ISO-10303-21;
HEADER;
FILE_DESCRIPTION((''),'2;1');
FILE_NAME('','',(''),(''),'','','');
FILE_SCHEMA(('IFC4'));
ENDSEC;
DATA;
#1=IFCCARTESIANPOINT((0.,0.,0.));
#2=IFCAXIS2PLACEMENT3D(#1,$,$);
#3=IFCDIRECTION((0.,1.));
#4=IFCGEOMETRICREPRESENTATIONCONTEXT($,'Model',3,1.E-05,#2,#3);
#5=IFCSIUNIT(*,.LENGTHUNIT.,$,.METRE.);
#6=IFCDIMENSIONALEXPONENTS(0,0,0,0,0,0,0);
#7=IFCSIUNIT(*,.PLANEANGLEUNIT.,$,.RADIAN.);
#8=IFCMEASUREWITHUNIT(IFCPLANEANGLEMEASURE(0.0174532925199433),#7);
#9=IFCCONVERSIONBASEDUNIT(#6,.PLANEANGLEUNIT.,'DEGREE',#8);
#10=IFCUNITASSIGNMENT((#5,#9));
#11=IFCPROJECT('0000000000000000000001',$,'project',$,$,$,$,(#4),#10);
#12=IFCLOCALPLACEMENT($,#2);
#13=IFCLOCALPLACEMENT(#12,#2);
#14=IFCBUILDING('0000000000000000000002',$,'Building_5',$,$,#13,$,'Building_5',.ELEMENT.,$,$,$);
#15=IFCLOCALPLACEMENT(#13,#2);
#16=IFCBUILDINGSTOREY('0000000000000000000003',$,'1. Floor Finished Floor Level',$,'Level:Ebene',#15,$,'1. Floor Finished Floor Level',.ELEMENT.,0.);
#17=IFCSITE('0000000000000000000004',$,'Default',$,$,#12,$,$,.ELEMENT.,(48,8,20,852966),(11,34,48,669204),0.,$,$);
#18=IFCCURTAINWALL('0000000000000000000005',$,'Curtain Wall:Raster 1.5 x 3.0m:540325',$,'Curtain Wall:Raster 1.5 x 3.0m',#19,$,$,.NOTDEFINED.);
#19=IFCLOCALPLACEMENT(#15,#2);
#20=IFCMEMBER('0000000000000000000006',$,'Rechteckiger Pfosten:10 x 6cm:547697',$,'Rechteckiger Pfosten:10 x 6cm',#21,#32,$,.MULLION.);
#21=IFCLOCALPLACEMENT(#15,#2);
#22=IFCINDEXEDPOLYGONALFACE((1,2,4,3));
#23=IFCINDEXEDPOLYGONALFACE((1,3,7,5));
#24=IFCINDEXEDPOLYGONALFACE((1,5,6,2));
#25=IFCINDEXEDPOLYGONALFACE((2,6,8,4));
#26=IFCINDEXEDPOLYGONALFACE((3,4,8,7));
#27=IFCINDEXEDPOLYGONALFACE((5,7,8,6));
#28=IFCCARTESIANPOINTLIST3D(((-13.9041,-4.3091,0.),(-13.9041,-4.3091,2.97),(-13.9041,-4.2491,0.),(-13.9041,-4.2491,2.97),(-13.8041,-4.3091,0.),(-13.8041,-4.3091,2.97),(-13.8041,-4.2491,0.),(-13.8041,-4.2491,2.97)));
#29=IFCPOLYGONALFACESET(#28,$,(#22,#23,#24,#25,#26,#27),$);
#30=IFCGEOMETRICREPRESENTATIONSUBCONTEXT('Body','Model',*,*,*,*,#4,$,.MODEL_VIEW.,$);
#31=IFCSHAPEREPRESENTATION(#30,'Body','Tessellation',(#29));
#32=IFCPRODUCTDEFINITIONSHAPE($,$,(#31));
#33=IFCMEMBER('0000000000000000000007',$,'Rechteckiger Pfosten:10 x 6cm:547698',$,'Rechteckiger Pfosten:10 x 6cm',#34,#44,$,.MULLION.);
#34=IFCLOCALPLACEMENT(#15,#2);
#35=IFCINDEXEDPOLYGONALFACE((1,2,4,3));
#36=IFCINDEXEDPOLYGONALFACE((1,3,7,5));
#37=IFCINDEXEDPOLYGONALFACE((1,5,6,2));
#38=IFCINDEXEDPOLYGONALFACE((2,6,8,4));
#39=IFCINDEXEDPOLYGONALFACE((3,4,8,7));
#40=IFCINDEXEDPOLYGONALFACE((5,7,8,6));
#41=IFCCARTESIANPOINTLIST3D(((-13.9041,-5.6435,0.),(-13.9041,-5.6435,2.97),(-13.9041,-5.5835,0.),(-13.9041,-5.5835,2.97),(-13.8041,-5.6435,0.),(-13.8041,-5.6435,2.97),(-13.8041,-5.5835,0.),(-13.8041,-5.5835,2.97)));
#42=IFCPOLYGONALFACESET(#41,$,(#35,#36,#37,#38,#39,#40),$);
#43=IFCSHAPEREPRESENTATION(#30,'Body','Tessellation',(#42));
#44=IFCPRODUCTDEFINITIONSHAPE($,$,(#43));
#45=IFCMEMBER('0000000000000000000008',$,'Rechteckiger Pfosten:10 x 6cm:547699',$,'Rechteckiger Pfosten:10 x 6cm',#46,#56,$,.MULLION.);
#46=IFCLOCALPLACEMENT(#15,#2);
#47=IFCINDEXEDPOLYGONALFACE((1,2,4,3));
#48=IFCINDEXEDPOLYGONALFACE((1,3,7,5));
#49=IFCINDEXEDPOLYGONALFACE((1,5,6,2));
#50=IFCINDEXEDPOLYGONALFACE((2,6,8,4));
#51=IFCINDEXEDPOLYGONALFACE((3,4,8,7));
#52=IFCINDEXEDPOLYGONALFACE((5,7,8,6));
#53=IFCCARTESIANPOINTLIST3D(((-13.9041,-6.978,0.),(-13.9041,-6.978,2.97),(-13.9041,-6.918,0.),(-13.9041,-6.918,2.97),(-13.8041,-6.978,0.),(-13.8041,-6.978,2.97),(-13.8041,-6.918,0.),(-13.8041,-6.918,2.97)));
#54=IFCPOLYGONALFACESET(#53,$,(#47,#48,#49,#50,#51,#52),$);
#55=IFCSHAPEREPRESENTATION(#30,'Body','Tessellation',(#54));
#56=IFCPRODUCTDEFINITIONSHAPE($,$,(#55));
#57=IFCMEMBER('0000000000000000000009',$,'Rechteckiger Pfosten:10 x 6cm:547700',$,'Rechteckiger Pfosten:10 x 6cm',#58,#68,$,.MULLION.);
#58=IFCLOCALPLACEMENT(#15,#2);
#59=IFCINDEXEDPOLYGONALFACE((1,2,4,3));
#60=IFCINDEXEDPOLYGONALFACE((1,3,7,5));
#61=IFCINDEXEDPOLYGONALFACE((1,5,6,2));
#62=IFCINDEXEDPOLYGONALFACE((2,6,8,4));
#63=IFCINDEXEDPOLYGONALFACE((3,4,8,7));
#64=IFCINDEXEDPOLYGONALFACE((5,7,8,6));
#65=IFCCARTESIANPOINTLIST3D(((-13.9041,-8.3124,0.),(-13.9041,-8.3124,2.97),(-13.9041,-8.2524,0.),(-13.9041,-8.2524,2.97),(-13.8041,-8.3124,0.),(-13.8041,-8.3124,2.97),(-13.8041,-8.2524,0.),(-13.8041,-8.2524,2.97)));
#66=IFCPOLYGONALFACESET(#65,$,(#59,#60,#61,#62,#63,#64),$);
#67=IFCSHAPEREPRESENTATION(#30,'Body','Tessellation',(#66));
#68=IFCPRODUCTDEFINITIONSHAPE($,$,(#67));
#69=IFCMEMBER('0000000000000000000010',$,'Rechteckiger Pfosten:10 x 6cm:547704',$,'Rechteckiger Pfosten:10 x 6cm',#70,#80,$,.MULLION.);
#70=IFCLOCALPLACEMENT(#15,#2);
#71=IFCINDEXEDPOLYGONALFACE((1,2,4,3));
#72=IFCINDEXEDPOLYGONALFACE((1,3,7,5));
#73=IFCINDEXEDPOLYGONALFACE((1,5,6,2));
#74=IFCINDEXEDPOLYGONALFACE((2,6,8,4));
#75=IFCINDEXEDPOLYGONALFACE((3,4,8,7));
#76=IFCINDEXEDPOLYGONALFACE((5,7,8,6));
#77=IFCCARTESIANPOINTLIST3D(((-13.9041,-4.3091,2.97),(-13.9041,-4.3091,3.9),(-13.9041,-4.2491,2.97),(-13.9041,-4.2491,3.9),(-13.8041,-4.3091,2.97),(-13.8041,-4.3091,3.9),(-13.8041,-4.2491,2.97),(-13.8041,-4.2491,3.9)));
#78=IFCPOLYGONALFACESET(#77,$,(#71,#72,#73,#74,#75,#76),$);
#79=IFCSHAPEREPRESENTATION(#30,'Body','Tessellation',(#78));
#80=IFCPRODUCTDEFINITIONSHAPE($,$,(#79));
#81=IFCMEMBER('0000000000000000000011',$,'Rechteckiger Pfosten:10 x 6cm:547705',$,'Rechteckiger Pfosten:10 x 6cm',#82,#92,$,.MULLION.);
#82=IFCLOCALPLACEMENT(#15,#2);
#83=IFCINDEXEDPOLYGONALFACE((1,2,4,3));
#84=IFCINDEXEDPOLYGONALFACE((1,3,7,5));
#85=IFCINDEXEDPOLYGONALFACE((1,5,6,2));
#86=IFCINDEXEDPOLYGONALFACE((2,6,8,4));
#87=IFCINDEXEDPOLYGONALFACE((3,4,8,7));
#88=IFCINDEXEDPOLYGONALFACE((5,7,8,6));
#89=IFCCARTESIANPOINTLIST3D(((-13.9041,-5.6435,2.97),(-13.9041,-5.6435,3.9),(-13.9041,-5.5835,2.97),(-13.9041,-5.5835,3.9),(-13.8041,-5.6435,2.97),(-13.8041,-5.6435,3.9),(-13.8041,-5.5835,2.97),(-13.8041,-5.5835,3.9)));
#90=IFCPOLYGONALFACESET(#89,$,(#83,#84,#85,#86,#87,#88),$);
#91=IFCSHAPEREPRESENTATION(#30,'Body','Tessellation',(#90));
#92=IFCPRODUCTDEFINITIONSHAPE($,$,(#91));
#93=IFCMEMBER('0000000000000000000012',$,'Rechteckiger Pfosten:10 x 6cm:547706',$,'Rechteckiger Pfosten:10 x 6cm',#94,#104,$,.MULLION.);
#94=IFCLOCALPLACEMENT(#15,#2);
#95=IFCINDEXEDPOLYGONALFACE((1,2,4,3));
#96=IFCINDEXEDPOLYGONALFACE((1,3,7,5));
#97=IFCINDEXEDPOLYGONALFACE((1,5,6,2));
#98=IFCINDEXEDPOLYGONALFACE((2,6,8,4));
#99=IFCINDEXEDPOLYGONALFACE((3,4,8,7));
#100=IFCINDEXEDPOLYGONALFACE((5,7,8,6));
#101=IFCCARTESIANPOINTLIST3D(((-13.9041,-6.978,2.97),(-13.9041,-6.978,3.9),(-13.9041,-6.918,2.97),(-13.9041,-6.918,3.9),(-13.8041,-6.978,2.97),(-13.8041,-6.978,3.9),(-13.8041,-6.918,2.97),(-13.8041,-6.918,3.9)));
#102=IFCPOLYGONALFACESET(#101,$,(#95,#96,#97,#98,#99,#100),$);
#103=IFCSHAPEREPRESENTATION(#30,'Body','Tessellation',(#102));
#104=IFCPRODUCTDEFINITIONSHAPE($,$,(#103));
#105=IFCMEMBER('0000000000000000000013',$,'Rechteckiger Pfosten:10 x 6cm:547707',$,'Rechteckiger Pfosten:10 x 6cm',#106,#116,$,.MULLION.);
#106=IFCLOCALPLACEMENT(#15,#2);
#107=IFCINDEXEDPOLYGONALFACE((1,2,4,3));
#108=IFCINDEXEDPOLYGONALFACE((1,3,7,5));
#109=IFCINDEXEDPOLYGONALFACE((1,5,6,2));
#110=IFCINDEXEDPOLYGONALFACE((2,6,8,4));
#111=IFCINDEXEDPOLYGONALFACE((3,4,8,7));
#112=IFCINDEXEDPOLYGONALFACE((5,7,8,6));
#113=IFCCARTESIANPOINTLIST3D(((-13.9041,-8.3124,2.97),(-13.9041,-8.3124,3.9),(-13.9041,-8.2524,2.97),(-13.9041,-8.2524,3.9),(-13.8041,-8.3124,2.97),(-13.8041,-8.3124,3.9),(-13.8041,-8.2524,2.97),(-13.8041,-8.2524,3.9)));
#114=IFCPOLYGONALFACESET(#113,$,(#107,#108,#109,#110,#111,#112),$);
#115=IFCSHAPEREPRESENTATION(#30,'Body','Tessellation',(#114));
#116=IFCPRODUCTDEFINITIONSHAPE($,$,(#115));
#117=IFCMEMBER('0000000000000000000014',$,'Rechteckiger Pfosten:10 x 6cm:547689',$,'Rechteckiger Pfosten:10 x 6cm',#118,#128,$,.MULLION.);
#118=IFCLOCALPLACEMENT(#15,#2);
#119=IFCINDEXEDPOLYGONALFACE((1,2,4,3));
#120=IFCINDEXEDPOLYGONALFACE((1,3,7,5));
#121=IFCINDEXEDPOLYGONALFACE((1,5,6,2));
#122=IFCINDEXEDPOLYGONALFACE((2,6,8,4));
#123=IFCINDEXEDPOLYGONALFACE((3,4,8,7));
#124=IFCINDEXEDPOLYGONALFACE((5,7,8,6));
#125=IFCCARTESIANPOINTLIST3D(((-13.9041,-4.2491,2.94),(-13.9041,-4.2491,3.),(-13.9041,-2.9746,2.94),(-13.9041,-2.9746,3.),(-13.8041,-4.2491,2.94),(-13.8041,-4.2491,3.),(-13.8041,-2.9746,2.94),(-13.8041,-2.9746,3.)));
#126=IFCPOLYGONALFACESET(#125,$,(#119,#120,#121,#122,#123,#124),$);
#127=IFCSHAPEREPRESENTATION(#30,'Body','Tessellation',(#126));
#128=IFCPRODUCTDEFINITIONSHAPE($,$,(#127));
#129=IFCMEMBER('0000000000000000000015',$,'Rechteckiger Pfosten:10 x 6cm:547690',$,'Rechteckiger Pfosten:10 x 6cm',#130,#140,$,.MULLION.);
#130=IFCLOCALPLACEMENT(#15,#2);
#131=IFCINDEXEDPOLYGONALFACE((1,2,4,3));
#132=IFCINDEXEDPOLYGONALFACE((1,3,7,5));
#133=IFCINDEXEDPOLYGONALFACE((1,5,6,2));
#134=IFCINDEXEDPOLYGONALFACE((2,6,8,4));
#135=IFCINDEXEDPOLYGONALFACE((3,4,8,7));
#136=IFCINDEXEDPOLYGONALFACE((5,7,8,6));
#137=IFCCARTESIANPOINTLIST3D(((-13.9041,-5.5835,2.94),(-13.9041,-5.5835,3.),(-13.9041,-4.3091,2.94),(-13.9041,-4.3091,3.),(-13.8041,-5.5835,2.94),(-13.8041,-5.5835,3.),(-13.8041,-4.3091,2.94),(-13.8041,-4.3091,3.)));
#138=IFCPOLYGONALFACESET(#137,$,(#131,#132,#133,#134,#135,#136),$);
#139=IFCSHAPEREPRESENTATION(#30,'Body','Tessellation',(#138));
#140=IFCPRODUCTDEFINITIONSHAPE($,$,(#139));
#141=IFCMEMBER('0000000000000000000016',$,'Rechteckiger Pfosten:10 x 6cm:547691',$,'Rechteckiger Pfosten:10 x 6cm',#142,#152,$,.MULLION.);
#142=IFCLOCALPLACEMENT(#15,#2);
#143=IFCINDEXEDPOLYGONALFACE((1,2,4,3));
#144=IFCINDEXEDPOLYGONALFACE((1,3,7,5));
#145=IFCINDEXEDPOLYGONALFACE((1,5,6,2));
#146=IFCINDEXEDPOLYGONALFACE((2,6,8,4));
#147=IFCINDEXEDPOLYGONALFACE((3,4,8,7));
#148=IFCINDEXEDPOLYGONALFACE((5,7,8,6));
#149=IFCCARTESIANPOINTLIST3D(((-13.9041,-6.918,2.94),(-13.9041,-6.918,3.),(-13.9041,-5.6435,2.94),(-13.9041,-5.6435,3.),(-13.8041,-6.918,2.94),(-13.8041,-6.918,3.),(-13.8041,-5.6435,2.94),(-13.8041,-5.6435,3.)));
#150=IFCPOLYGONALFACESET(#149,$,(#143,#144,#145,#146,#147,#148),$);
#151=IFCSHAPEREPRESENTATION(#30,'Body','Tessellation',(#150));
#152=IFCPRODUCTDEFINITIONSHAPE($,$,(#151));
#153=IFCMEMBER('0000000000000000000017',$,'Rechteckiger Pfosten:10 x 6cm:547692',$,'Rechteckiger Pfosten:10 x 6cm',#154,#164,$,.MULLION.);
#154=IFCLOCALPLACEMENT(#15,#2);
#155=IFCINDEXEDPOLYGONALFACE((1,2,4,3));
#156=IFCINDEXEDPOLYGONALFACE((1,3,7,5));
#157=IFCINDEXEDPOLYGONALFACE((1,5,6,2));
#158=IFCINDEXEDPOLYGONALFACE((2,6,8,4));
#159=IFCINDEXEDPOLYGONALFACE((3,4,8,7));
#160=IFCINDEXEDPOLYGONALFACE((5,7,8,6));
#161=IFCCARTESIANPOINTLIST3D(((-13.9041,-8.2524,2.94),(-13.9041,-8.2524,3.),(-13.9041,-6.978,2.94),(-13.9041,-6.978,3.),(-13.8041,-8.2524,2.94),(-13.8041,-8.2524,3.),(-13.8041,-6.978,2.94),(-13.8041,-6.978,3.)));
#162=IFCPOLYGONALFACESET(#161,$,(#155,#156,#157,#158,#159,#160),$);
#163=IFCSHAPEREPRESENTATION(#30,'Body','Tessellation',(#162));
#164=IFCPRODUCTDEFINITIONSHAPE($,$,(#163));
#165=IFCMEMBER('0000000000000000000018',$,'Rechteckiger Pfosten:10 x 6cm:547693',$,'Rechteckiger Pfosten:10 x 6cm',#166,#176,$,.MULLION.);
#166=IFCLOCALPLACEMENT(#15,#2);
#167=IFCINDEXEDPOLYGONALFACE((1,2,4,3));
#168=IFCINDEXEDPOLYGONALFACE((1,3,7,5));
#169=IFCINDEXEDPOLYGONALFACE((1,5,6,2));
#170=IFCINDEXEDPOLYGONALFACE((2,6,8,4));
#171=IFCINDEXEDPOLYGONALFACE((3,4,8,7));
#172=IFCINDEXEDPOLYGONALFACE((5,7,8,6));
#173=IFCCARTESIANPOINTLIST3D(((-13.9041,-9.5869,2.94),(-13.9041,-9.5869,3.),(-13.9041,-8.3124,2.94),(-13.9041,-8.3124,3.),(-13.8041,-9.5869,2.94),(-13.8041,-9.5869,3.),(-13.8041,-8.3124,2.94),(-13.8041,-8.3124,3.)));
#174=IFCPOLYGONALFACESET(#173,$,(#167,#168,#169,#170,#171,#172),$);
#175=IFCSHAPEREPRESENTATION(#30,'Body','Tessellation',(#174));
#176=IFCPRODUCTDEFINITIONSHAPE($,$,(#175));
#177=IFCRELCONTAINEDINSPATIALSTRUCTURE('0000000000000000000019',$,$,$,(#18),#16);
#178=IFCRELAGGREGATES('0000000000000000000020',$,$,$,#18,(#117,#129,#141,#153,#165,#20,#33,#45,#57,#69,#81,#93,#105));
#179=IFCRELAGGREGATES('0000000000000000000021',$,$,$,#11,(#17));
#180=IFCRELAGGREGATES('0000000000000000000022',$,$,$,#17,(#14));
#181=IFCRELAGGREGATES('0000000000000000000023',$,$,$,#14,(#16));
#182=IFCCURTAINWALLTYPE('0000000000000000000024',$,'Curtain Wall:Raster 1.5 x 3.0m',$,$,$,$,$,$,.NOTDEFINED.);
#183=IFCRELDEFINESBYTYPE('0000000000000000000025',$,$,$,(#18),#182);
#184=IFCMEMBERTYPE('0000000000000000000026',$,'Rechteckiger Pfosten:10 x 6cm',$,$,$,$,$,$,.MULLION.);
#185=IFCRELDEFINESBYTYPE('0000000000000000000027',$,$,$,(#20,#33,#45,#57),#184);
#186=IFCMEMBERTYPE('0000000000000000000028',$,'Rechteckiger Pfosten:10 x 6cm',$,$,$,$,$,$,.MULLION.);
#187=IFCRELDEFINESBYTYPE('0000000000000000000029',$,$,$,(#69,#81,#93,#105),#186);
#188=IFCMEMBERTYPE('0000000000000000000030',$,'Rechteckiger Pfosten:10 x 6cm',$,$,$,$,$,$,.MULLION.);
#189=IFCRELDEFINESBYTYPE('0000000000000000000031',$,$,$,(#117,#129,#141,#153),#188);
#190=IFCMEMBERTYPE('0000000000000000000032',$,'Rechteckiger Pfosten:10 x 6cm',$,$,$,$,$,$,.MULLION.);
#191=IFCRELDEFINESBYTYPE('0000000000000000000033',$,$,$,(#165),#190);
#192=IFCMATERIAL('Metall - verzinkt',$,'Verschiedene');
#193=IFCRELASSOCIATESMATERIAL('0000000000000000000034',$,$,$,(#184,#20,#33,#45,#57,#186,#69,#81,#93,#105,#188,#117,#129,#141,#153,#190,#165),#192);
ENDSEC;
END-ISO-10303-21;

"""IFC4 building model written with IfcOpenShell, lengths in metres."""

from ifc_helpers import new_model, entity, si_unit, converted_unit, direction, frame, origin, place, context, subcontext, project, spatial, indexed_curve, outline, extrude, source, transform, mapped, material, type_object, type_shapes, element, aggregate, save


model = new_model("IFC4")

# Units and contexts
model_context = context("Model", 3, precision=1e-05, world=origin(), true_north=direction((0.0, 1.0)))
body_context = subcontext(model_context, "Body", "Model", "MODEL_VIEW")
ifc_project = project(units=[si_unit("LENGTHUNIT", "METRE"), converted_unit("PLANEANGLEUNIT", "DEGREE", entity("IfcPlaneAngleMeasure", 0.0174532925199433), si_unit("PLANEANGLEUNIT", "RADIAN"), dimensions=[0, 0, 0, 0, 0, 0, 0])], contexts=[model_context])

# Site, building, storey
site_placement = place(None, origin())
site = spatial("IfcSite", under=ifc_project, at=site_placement, Name="Default", CompositionType="ELEMENT", RefLatitude=(48, 8, 20, 852966), RefLongitude=(11, 34, 48, 669204), RefElevation=0.0)
building_placement = place(site_placement, origin())
building = spatial("IfcBuilding", under=site, at=building_placement, Name="Building_5", LongName="Building_5", CompositionType="ELEMENT")
storey_placement = place(building_placement, origin())
storey = spatial("IfcBuildingStorey", under=building, at=storey_placement, Name="1. Floor Finished Floor Level", ObjectType="Level:Ebene", LongName="1. Floor Finished Floor Level", CompositionType="ELEMENT", Elevation=0.0)

# Curtain wall, members
curtain_wall_type = type_object("IfcCurtainWallType", Name="Curtain Wall:Raster 1.5 x 3.0m", PredefinedType="NOTDEFINED")
curtain_wall_placement = place(storey_placement, origin())
curtain_wall = element("IfcCurtainWall", 1, at=curtain_wall_placement, inside=storey, type_object=curtain_wall_type, Name="Curtain Wall:Raster 1.5 x 3.0m:540325", ObjectType="Curtain Wall:Raster 1.5 x 3.0m", PredefinedType="NOTDEFINED")
ifc_material_1 = material(Name="Metall - verzinkt", Category="Verschiedene")
member_type_1 = type_object("IfcMemberType", Name="Rechteckiger Pfosten:10 x 6cm", PredefinedType="MULLION", material=ifc_material_1)
shared_shape_1 = source(origin(), body_context, "Body", "SweptSolid", [
    extrude(outline(indexed_curve([(-0.03, -0.05), (0.03, -0.05), (0.03, 0.05), (-0.03, 0.05), (-0.03, -0.05)], self_intersect=False)), frame((0.0, 0.0, -2.97), z_axis=(0.0, 0.0, 1.0), x_axis=(-1.0, 0.0, 0.0)), (0.0, 0.0, 1.0), 2.97),
])
type_shapes(member_type_1, [shared_shape_1])
member_1_placement = place(curtain_wall_placement, frame((-13.8541, -4.2791, 0.0), z_axis=(0.0, 0.0, -1.0), x_axis=(0.0, -1.0, 0.0)))
member_1 = element("IfcMember", 2, at=member_1_placement, type_object=member_type_1, material=ifc_material_1, Name="Rechteckiger Pfosten:10 x 6cm:547697", ObjectType="Rechteckiger Pfosten:10 x 6cm", PredefinedType="MULLION", context=body_context, shape_type="MappedRepresentation", body=[
    mapped(shared_shape_1, transform((0.0, 0.0, 0.0), scale=1.0)),
])
member_2_placement = place(curtain_wall_placement, frame((-13.8541, -5.6135, 0.0), z_axis=(0.0, 0.0, -1.0), x_axis=(0.0, -1.0, 0.0)))
member_2 = element("IfcMember", 3, at=member_2_placement, type_object=member_type_1, material=ifc_material_1, Name="Rechteckiger Pfosten:10 x 6cm:547698", ObjectType="Rechteckiger Pfosten:10 x 6cm", PredefinedType="MULLION", context=body_context, shape_type="MappedRepresentation", body=[
    mapped(shared_shape_1, transform((0.0, 0.0, 0.0), scale=1.0)),
])
member_3_placement = place(curtain_wall_placement, frame((-13.8541, -6.948, 0.0), z_axis=(0.0, 0.0, -1.0), x_axis=(0.0, -1.0, 0.0)))
member_3 = element("IfcMember", 4, at=member_3_placement, type_object=member_type_1, material=ifc_material_1, Name="Rechteckiger Pfosten:10 x 6cm:547699", ObjectType="Rechteckiger Pfosten:10 x 6cm", PredefinedType="MULLION", context=body_context, shape_type="MappedRepresentation", body=[
    mapped(shared_shape_1, transform((0.0, 0.0, 0.0), scale=1.0)),
])
member_4_placement = place(curtain_wall_placement, frame((-13.8541, -8.2824, 0.0), z_axis=(0.0, 0.0, -1.0), x_axis=(0.0, -1.0, 0.0)))
member_4 = element("IfcMember", 5, at=member_4_placement, type_object=member_type_1, material=ifc_material_1, Name="Rechteckiger Pfosten:10 x 6cm:547700", ObjectType="Rechteckiger Pfosten:10 x 6cm", PredefinedType="MULLION", context=body_context, shape_type="MappedRepresentation", body=[
    mapped(shared_shape_1, transform((0.0, 0.0, 0.0), scale=1.0)),
])
member_type_2 = type_object("IfcMemberType", Name="Rechteckiger Pfosten:10 x 6cm", PredefinedType="MULLION", material=ifc_material_1)
shared_shape_2 = source(origin(), body_context, "Body", "SweptSolid", [
    extrude(outline(indexed_curve([(-0.03, -0.05), (0.03, -0.05), (0.03, 0.05), (-0.03, 0.05), (-0.03, -0.05)], self_intersect=False)), frame((0.0, 0.0, -0.93), z_axis=(0.0, 0.0, 1.0), x_axis=(-1.0, 0.0, 0.0)), (0.0, 0.0, 1.0), 0.93),
])
type_shapes(member_type_2, [shared_shape_2])
member_5_placement = place(curtain_wall_placement, frame((-13.8541, -4.2791, 2.97), z_axis=(0.0, 0.0, -1.0), x_axis=(0.0, -1.0, 0.0)))
member_5 = element("IfcMember", 6, at=member_5_placement, type_object=member_type_2, material=ifc_material_1, Name="Rechteckiger Pfosten:10 x 6cm:547704", ObjectType="Rechteckiger Pfosten:10 x 6cm", PredefinedType="MULLION", context=body_context, shape_type="MappedRepresentation", body=[
    mapped(shared_shape_2, transform((0.0, 0.0, 0.0), scale=1.0)),
])
member_6_placement = place(curtain_wall_placement, frame((-13.8541, -5.6135, 2.97), z_axis=(0.0, 0.0, -1.0), x_axis=(0.0, -1.0, 0.0)))
member_6 = element("IfcMember", 7, at=member_6_placement, type_object=member_type_2, material=ifc_material_1, Name="Rechteckiger Pfosten:10 x 6cm:547705", ObjectType="Rechteckiger Pfosten:10 x 6cm", PredefinedType="MULLION", context=body_context, shape_type="MappedRepresentation", body=[
    mapped(shared_shape_2, transform((0.0, 0.0, 0.0), scale=1.0)),
])
member_7_placement = place(curtain_wall_placement, frame((-13.8541, -6.948, 2.97), z_axis=(0.0, 0.0, -1.0), x_axis=(0.0, -1.0, 0.0)))
member_7 = element("IfcMember", 8, at=member_7_placement, type_object=member_type_2, material=ifc_material_1, Name="Rechteckiger Pfosten:10 x 6cm:547706", ObjectType="Rechteckiger Pfosten:10 x 6cm", PredefinedType="MULLION", context=body_context, shape_type="MappedRepresentation", body=[
    mapped(shared_shape_2, transform((0.0, 0.0, 0.0), scale=1.0)),
])
member_8_placement = place(curtain_wall_placement, frame((-13.8541, -8.2824, 2.97), z_axis=(0.0, 0.0, -1.0), x_axis=(0.0, -1.0, 0.0)))
member_8 = element("IfcMember", 9, at=member_8_placement, type_object=member_type_2, material=ifc_material_1, Name="Rechteckiger Pfosten:10 x 6cm:547707", ObjectType="Rechteckiger Pfosten:10 x 6cm", PredefinedType="MULLION", context=body_context, shape_type="MappedRepresentation", body=[
    mapped(shared_shape_2, transform((0.0, 0.0, 0.0), scale=1.0)),
])
member_type_3 = type_object("IfcMemberType", Name="Rechteckiger Pfosten:10 x 6cm", PredefinedType="MULLION", material=ifc_material_1)
shared_shape_3 = source(origin(), body_context, "Body", "SweptSolid", [
    extrude(outline(indexed_curve([(-0.03, -0.05), (0.03, -0.05), (0.03, 0.05), (-0.03, 0.05), (-0.03, -0.05)], self_intersect=False)), frame((0.0, 0.0, -1.2744), z_axis=(0.0, 0.0, 1.0), x_axis=(-1.0, 0.0, 0.0)), (0.0, 0.0, 1.0), 1.2744),
])
type_shapes(member_type_3, [shared_shape_3])
member_9_placement = place(curtain_wall_placement, frame((-13.8541, -4.2491, 2.97), z_axis=(0.0, -1.0, 0.0), x_axis=(0.0, 0.0, 1.0)))
member_9 = element("IfcMember", 10, at=member_9_placement, type_object=member_type_3, material=ifc_material_1, Name="Rechteckiger Pfosten:10 x 6cm:547689", ObjectType="Rechteckiger Pfosten:10 x 6cm", PredefinedType="MULLION", context=body_context, shape_type="MappedRepresentation", body=[
    mapped(shared_shape_3, transform((0.0, 0.0, 0.0), scale=1.0)),
])
member_10_placement = place(curtain_wall_placement, frame((-13.8541, -5.5835, 2.97), z_axis=(0.0, -1.0, 0.0), x_axis=(0.0, 0.0, 1.0)))
member_10 = element("IfcMember", 11, at=member_10_placement, type_object=member_type_3, material=ifc_material_1, Name="Rechteckiger Pfosten:10 x 6cm:547690", ObjectType="Rechteckiger Pfosten:10 x 6cm", PredefinedType="MULLION", context=body_context, shape_type="MappedRepresentation", body=[
    mapped(shared_shape_3, transform((0.0, 0.0, 0.0), scale=1.0)),
])
member_11_placement = place(curtain_wall_placement, frame((-13.8541, -6.918, 2.97), z_axis=(0.0, -1.0, 0.0), x_axis=(0.0, 0.0, 1.0)))
member_11 = element("IfcMember", 12, at=member_11_placement, type_object=member_type_3, material=ifc_material_1, Name="Rechteckiger Pfosten:10 x 6cm:547691", ObjectType="Rechteckiger Pfosten:10 x 6cm", PredefinedType="MULLION", context=body_context, shape_type="MappedRepresentation", body=[
    mapped(shared_shape_3, transform((0.0, 0.0, 0.0), scale=1.0)),
])
member_12_placement = place(curtain_wall_placement, frame((-13.8541, -8.2524, 2.97), z_axis=(0.0, -1.0, 0.0), x_axis=(0.0, 0.0, 1.0)))
member_12 = element("IfcMember", 13, at=member_12_placement, type_object=member_type_3, material=ifc_material_1, Name="Rechteckiger Pfosten:10 x 6cm:547692", ObjectType="Rechteckiger Pfosten:10 x 6cm", PredefinedType="MULLION", context=body_context, shape_type="MappedRepresentation", body=[
    mapped(shared_shape_3, transform((0.0, 0.0, 0.0), scale=1.0)),
])
member_type_4 = type_object("IfcMemberType", Name="Rechteckiger Pfosten:10 x 6cm", PredefinedType="MULLION", material=ifc_material_1)
shared_shape_4 = source(origin(), body_context, "Body", "SweptSolid", [
    extrude(outline(indexed_curve([(-0.03, -0.05), (0.03, -0.05), (0.03, 0.05), (-0.03, 0.05), (-0.03, -0.05)], self_intersect=False)), frame((0.0, 0.0, -1.2744), z_axis=(0.0, 0.0, 1.0), x_axis=(-1.0, 0.0, 0.0)), (0.0, 0.0, 1.0), 1.2744),
])
type_shapes(member_type_4, [shared_shape_4])
member_13_placement = place(curtain_wall_placement, frame((-13.8541, -9.5869, 2.97), z_axis=(0.0, -1.0, 0.0), x_axis=(0.0, 0.0, 1.0)))
member_13 = element("IfcMember", 14, at=member_13_placement, type_object=member_type_4, material=ifc_material_1, Name="Rechteckiger Pfosten:10 x 6cm:547693", ObjectType="Rechteckiger Pfosten:10 x 6cm", PredefinedType="MULLION", context=body_context, shape_type="MappedRepresentation", body=[
    mapped(shared_shape_4, transform((0.0, 0.0, 0.0), scale=1.0)),
])
aggregate(curtain_wall, [member_9, member_10, member_11, member_12, member_13, member_1, member_2, member_3, member_4, member_5, member_6, member_7, member_8])

save(model, "model.ifc")
